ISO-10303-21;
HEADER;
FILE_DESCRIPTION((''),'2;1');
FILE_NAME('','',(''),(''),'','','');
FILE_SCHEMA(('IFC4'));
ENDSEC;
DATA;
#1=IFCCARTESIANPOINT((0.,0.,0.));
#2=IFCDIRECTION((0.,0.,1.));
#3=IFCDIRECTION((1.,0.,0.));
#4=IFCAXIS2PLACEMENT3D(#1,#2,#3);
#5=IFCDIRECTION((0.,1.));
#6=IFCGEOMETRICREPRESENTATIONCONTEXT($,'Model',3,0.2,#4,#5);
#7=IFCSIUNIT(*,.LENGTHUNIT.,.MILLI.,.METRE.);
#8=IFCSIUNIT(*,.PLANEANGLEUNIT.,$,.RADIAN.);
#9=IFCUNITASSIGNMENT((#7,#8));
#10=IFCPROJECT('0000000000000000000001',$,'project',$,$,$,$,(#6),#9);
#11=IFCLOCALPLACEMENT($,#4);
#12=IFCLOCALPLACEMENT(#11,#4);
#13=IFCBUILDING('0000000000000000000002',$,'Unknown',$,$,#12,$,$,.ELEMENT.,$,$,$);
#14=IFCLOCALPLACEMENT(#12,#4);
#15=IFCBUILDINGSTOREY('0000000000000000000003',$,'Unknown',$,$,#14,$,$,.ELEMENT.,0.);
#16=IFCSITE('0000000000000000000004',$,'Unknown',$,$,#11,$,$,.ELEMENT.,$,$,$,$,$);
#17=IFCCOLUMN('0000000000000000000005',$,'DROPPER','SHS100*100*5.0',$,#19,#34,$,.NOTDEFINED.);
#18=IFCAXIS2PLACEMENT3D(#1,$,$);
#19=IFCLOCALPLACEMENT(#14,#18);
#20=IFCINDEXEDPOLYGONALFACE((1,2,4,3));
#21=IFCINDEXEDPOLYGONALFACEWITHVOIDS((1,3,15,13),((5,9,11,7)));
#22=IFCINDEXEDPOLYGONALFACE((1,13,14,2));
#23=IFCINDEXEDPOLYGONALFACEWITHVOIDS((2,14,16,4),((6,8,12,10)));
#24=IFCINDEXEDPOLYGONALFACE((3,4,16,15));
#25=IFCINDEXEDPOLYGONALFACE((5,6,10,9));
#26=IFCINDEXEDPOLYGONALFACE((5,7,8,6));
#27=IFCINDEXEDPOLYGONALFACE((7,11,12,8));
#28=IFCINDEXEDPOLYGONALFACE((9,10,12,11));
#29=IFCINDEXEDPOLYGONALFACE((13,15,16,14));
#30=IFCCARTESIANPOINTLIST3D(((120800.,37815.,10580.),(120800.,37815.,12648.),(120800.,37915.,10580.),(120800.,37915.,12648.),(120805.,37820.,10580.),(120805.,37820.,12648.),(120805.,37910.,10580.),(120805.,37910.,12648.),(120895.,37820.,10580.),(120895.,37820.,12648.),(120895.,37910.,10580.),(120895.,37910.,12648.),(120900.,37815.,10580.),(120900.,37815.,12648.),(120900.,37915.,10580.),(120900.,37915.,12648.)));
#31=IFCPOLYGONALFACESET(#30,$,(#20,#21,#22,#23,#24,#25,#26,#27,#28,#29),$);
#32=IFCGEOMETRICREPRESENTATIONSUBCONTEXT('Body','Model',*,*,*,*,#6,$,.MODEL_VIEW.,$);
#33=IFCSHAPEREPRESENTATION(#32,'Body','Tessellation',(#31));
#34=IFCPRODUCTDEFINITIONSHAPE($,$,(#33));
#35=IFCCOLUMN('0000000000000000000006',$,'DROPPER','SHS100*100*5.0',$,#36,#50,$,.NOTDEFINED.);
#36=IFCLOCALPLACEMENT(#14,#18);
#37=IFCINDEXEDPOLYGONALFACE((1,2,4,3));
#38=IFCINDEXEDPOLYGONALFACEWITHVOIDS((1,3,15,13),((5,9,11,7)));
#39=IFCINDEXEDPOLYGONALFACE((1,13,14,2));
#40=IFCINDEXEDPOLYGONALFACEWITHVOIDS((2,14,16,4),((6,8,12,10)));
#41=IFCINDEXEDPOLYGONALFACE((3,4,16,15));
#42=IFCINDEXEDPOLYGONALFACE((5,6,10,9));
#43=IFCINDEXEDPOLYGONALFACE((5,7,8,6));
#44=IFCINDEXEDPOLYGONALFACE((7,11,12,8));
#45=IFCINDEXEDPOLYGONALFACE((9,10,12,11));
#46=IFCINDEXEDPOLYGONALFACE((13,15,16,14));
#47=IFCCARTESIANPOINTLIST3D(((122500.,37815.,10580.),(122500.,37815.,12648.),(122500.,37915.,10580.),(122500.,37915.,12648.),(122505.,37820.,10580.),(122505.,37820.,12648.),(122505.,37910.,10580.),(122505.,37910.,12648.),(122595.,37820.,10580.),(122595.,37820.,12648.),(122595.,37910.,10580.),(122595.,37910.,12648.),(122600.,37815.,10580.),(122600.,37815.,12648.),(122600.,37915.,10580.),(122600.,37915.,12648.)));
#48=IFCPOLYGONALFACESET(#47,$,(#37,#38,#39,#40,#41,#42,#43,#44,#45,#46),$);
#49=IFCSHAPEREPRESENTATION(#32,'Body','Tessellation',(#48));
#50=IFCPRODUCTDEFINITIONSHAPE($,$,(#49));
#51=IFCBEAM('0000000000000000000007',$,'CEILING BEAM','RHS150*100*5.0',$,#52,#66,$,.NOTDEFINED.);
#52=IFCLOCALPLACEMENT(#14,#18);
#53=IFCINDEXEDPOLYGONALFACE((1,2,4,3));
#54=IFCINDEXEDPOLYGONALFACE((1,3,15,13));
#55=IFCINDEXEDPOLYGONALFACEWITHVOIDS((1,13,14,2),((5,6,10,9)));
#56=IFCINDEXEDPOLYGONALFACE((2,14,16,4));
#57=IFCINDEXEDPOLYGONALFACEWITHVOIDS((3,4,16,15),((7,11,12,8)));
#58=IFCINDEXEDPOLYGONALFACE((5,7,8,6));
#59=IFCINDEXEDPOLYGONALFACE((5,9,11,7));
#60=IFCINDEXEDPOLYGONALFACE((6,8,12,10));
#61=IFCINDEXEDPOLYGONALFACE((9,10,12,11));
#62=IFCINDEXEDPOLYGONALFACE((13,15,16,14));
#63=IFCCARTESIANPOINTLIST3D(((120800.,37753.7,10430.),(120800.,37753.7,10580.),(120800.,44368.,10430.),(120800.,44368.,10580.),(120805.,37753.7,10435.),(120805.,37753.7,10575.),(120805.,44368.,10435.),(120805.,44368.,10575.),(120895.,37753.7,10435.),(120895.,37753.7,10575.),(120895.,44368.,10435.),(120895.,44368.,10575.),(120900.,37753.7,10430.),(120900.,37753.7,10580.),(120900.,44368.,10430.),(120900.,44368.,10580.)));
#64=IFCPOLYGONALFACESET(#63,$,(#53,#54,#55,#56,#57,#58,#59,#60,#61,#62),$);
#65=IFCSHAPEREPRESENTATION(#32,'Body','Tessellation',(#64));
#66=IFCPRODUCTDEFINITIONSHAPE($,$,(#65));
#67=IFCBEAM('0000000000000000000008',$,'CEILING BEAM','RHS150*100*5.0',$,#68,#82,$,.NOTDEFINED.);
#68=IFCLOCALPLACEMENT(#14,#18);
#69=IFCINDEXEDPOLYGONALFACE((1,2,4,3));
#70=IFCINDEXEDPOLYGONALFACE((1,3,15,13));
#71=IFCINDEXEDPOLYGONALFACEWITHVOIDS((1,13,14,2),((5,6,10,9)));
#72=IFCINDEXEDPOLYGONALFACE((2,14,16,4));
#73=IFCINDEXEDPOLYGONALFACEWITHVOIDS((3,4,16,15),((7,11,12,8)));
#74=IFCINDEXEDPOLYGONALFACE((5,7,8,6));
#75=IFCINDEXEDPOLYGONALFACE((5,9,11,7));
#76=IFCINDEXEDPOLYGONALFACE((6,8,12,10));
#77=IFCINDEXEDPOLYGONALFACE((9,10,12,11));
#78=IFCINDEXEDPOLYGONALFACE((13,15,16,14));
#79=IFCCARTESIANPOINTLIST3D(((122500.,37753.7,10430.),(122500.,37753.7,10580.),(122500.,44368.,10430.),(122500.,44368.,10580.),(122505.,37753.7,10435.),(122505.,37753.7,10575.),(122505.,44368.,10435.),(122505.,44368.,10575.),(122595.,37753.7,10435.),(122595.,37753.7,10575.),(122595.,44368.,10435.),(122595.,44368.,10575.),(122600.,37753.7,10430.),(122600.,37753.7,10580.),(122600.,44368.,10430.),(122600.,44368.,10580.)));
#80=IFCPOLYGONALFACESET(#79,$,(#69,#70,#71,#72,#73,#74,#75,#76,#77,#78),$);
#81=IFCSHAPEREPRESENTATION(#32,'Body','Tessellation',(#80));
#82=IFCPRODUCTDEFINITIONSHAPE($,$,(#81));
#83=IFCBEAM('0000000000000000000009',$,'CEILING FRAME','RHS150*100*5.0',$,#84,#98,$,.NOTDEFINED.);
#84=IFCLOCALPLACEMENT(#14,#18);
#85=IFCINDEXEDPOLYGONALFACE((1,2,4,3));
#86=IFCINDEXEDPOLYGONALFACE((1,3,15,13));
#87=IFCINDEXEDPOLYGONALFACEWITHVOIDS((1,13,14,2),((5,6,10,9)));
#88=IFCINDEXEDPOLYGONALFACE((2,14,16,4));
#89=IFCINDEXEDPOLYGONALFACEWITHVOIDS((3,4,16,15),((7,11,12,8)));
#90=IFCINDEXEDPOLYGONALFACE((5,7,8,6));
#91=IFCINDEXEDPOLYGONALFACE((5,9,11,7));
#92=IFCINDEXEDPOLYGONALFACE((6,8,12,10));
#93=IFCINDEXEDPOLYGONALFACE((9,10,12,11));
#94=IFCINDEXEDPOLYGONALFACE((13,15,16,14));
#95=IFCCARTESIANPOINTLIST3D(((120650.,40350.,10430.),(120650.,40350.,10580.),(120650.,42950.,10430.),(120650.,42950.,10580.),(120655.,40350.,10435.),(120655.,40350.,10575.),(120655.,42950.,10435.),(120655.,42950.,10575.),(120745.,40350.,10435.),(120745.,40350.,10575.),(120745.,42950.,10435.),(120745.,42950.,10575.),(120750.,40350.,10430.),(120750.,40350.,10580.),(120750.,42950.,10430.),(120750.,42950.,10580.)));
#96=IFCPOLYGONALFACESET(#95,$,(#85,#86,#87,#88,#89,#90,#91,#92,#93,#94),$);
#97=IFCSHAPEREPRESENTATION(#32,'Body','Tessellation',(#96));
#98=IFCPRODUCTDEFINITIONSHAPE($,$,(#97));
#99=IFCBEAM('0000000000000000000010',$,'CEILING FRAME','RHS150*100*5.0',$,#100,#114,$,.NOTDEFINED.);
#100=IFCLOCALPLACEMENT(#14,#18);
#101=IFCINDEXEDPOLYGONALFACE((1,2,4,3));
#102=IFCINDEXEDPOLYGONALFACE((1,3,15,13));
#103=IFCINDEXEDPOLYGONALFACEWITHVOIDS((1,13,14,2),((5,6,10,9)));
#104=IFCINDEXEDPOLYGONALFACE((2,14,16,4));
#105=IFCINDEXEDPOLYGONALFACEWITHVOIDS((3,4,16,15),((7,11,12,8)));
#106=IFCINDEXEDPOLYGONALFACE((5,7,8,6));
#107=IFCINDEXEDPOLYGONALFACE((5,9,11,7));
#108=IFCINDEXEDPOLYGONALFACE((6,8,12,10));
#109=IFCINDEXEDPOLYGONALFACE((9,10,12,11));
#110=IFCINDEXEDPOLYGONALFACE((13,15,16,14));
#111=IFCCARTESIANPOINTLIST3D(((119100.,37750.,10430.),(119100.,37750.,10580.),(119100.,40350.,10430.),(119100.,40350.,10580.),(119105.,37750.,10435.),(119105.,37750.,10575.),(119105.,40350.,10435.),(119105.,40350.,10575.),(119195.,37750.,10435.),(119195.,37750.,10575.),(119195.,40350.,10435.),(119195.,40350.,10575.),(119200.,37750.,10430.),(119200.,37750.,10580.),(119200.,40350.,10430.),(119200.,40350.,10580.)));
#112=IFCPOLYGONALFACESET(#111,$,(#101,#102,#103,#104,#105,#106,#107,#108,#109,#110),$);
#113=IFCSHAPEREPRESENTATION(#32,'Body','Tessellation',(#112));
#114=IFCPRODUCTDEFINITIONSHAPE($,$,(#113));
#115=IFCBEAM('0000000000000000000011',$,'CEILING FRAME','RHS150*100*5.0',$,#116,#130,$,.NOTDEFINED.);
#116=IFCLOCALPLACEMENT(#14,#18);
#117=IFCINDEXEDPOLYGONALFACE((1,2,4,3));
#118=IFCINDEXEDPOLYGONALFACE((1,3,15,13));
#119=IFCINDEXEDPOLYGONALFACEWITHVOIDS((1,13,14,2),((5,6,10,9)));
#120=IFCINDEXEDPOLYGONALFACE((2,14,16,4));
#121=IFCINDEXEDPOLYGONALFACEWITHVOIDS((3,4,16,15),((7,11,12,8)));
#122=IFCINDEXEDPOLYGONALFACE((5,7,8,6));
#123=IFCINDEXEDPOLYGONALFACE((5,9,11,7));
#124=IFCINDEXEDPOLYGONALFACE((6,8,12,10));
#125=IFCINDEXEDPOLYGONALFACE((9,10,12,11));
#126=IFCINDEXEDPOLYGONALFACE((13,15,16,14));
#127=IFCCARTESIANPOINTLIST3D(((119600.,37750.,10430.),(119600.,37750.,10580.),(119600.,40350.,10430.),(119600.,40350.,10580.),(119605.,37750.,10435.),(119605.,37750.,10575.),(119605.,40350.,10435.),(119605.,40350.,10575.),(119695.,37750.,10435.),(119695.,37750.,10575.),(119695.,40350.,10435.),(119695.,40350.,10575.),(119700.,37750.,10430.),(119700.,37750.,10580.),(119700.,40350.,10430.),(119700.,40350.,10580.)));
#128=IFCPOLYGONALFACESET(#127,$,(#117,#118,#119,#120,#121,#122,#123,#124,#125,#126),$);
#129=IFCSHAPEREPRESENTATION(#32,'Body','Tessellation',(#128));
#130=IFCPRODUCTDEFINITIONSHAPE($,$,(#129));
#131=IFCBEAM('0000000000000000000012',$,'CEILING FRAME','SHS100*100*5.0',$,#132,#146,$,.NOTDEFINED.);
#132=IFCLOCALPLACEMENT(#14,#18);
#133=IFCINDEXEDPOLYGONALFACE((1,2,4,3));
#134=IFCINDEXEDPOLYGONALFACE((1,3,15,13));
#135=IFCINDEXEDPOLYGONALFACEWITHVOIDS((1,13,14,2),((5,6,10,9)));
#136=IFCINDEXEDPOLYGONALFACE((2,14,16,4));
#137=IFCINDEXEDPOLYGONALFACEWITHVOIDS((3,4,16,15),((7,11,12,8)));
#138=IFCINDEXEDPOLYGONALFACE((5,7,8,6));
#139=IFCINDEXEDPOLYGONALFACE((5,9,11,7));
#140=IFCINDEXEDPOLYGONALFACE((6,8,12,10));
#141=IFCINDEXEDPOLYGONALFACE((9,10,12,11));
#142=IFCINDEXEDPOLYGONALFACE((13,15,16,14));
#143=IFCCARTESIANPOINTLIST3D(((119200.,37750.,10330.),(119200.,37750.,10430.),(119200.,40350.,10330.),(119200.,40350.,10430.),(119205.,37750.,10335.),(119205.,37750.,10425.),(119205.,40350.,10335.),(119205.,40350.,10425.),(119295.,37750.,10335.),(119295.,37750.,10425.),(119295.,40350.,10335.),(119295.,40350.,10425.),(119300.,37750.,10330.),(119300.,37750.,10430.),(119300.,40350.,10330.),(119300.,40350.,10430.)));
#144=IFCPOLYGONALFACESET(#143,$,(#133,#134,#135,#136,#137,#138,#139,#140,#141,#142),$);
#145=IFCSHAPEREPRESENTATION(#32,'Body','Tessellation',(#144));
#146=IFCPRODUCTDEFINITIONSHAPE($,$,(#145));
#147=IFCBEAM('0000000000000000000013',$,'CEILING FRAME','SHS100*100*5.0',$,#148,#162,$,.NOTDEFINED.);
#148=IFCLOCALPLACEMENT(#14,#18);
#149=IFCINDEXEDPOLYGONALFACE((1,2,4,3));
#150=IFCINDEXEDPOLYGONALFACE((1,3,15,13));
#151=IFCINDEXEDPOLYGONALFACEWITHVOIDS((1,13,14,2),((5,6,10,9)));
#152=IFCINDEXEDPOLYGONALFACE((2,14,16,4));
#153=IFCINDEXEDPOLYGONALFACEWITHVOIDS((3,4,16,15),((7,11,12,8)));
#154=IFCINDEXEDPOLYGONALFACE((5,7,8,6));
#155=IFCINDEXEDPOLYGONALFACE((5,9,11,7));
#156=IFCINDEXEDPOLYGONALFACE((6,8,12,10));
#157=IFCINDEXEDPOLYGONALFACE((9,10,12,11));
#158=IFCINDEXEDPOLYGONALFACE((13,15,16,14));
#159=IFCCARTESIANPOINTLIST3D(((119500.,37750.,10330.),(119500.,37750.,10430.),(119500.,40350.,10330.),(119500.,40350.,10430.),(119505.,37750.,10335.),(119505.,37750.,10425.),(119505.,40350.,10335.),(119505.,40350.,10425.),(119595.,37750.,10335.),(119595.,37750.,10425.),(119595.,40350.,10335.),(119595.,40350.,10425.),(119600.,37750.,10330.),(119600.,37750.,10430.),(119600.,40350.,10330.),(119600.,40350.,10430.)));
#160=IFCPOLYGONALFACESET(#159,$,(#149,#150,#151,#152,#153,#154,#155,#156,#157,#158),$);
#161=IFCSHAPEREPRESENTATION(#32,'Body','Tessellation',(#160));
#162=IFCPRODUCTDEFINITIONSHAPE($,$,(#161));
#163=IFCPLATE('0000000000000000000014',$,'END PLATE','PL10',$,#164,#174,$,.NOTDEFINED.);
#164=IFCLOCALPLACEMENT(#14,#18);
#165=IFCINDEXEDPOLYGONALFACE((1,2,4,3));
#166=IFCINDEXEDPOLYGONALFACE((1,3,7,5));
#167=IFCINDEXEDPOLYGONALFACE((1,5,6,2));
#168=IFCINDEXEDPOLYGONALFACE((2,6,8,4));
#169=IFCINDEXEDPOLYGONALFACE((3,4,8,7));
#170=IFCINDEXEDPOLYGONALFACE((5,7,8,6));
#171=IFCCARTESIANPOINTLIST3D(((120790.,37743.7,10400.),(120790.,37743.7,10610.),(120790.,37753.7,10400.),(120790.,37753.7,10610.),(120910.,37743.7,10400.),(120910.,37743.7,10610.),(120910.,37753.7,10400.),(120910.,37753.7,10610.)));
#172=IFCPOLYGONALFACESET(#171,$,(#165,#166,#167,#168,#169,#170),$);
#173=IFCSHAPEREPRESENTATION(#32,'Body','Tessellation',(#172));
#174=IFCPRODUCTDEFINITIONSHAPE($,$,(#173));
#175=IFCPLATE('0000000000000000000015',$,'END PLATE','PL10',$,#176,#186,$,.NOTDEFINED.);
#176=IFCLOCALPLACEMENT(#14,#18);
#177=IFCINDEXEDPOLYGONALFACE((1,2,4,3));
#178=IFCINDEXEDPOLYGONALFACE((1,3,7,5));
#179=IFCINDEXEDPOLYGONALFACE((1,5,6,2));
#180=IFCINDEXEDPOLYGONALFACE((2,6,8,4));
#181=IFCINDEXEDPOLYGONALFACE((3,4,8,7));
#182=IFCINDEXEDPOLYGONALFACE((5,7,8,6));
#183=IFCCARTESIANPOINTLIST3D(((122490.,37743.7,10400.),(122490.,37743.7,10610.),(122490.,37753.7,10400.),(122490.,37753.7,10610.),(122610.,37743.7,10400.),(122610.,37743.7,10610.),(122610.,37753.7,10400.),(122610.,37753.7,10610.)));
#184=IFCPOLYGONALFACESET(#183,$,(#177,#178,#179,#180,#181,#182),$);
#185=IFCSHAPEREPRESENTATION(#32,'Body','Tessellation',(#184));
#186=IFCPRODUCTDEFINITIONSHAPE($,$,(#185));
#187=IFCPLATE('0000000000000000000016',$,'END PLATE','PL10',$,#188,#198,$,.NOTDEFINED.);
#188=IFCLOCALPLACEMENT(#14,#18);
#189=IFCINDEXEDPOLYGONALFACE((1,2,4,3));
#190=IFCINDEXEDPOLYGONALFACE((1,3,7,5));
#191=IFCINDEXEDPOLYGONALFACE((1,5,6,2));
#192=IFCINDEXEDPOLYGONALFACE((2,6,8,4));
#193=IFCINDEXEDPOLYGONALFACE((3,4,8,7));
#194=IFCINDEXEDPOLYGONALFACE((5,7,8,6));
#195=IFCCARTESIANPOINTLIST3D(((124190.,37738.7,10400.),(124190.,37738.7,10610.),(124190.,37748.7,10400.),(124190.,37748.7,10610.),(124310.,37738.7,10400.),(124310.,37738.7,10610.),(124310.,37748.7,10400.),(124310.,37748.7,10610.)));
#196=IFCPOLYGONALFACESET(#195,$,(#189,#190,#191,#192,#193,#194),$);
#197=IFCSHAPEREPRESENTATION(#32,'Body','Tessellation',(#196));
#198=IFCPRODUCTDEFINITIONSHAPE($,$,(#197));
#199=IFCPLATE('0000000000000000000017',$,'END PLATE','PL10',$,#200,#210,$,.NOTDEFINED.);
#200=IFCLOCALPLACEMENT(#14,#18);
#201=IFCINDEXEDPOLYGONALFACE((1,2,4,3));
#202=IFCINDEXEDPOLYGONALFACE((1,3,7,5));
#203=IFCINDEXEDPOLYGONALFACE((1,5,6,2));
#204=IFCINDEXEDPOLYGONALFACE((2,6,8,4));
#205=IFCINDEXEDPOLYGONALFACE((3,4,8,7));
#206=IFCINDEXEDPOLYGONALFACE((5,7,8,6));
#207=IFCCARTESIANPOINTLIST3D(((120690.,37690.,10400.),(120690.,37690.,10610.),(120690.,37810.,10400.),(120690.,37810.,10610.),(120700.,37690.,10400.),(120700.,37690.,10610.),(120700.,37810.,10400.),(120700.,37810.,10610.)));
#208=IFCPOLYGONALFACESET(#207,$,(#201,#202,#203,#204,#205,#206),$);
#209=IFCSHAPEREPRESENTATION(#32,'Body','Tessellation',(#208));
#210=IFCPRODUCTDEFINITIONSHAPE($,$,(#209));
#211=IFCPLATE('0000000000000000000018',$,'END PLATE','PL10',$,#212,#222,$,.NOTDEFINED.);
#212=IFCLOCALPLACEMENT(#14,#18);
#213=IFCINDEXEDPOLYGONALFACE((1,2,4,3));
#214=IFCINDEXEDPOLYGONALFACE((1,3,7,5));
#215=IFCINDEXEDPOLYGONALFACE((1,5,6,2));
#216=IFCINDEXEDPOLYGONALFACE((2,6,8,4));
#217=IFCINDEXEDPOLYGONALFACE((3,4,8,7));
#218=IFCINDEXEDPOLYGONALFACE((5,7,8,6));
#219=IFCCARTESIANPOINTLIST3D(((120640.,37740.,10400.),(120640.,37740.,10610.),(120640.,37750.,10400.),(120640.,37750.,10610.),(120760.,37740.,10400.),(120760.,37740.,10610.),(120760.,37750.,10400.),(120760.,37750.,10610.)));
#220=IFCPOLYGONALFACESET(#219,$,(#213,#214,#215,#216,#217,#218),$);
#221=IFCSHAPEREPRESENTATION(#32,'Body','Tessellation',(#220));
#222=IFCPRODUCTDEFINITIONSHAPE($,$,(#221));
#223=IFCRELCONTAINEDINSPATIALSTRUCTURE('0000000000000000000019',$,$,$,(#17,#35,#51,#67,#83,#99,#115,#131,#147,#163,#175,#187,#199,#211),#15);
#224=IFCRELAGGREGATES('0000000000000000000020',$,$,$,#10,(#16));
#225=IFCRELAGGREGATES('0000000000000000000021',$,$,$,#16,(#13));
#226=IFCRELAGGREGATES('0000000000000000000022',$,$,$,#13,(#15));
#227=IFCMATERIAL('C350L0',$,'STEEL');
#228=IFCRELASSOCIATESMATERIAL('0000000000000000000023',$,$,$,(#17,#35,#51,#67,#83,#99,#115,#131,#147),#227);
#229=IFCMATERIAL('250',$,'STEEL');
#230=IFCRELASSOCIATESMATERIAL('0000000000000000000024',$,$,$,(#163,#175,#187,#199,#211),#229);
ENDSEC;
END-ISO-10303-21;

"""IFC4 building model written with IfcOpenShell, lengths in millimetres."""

from ifc_helpers import new_model, si_unit, direction, frame, origin_with_axes, place, context, subcontext, project, spatial, line, indexed_curve, outline, extrude, material, element, save


model = new_model("IFC4")

# Units and contexts
model_context = context("Model", 3, precision=0.2, world=origin_with_axes(), true_north=direction((0.0, 1.0)))
body_context = subcontext(model_context, "Body", "Model", "MODEL_VIEW")
ifc_project = project(units=[si_unit("LENGTHUNIT", "METRE", prefix="MILLI"), si_unit("PLANEANGLEUNIT", "RADIAN")], contexts=[model_context])

# Site, building, storey
site_placement = place(None, origin_with_axes())
site = spatial("IfcSite", under=ifc_project, at=site_placement, Name="Unknown", CompositionType="ELEMENT")
building_placement = place(site_placement, origin_with_axes())
building = spatial("IfcBuilding", under=site, at=building_placement, Name="Unknown", CompositionType="ELEMENT")
storey_placement = place(building_placement, origin_with_axes())
storey = spatial("IfcBuildingStorey", under=building, at=storey_placement, Name="Unknown", CompositionType="ELEMENT", Elevation=0.0)

# Columns
ifc_material_1 = material(Name="C350L0", Category="STEEL")
for number, where, z_axis, x_axis, name in (
    (1, (120850.0, 37865.0, 10580.0), (-1.0, 0.0, 0.0), (0.0, 0.0, 1.0), "DROPPER"),
    (2, (122550.0, 37865.0, 10580.0), (-1.0, 0.0, 0.0), (0.0, 0.0, 1.0), "DROPPER"),
):
    element("IfcColumn", number, at=place(storey_placement, frame(where, z_axis=z_axis, x_axis=x_axis)), inside=storey, material=ifc_material_1, Name=name, Description="SHS100*100*5.0", PredefinedType="NOTDEFINED", context=body_context, shape_type="SolidModel", body=[
        extrude(outline(indexed_curve([(-50.0, -50.0), (50.0, -50.0), (50.0, 50.0), (-50.0, 50.0)], segments=[line(1, 2, 3, 4, 1)]), holes=[indexed_curve([(-45.0, -45.0), (-45.0, 45.0), (45.0, 45.0), (45.0, -45.0)], segments=[line(1, 2, 3, 4, 1)])]), frame((0.0, 0.0, 0.0), z_axis=(-1.0, 0.0, 0.0), x_axis=(0.0, 0.0, 1.0)), (0.0, 0.0, -1.0), 2068.0),
    ])

# Beams
for number, where, z_axis, x_axis, name in (
    (3, (120850.0, 37753.7, 10505.0), (1.0, 0.0, 0.0), (0.0, 1.0, 0.0), "CEILING BEAM"),
    (4, (122550.0, 37753.7, 10505.0), (1.0, 0.0, 0.0), (0.0, 1.0, 0.0), "CEILING BEAM"),
):
    element("IfcBeam", number, at=place(storey_placement, frame(where, z_axis=z_axis, x_axis=x_axis)), inside=storey, material=ifc_material_1, Name=name, Description="RHS150*100*5.0", PredefinedType="NOTDEFINED", context=body_context, shape_type="SolidModel", body=[
        extrude(outline(indexed_curve([(-50.0, -75.0), (50.0, -75.0), (50.0, 75.0), (-50.0, 75.0)], segments=[line(1, 2, 3, 4, 1)]), holes=[indexed_curve([(-45.0, -70.0), (-45.0, 70.0), (45.0, 70.0), (45.0, -70.0)], segments=[line(1, 2, 3, 4, 1)])]), frame((0.0, 0.0, 0.0), z_axis=(-1.0, 0.0, 0.0), x_axis=(0.0, 0.0, 1.0)), (0.0, 0.0, -1.0), 6614.3),
    ])
for number, where, z_axis, x_axis, name in (
    (5, (120700.0, 40350.0, 10505.0), (1.0, 0.0, 0.0), (0.0, 1.0, 0.0), "CEILING FRAME"),
    (6, (119150.0, 37750.0, 10505.0), (1.0, 0.0, 0.0), (0.0, 1.0, 0.0), "CEILING FRAME"),
    (7, (119650.0, 37750.0, 10505.0), (1.0, 0.0, 0.0), (0.0, 1.0, 0.0), "CEILING FRAME"),
):
    element("IfcBeam", number, at=place(storey_placement, frame(where, z_axis=z_axis, x_axis=x_axis)), inside=storey, material=ifc_material_1, Name=name, Description="RHS150*100*5.0", PredefinedType="NOTDEFINED", context=body_context, shape_type="SolidModel", body=[
        extrude(outline(indexed_curve([(-50.0, -75.0), (50.0, -75.0), (50.0, 75.0), (-50.0, 75.0)], segments=[line(1, 2, 3, 4, 1)]), holes=[indexed_curve([(-45.0, -70.0), (-45.0, 70.0), (45.0, 70.0), (45.0, -70.0)], segments=[line(1, 2, 3, 4, 1)])]), frame((0.0, 0.0, 0.0), z_axis=(-1.0, 0.0, 0.0), x_axis=(0.0, 0.0, 1.0)), (0.0, 0.0, -1.0), 2600.0),
    ])
for number, where, z_axis, x_axis, name in (
    (8, (119250.0, 37750.0, 10380.0), (0.0, 0.0, 1.0), (0.0, 1.0, 0.0), "CEILING FRAME"),
    (9, (119550.0, 37750.0, 10380.0), (0.0, 0.0, 1.0), (0.0, 1.0, 0.0), "CEILING FRAME"),
):
    element("IfcBeam", number, at=place(storey_placement, frame(where, z_axis=z_axis, x_axis=x_axis)), inside=storey, material=ifc_material_1, Name=name, Description="SHS100*100*5.0", PredefinedType="NOTDEFINED", context=body_context, shape_type="SolidModel", body=[
        extrude(outline(indexed_curve([(-50.0, -50.0), (50.0, -50.0), (50.0, 50.0), (-50.0, 50.0)], segments=[line(1, 2, 3, 4, 1)]), holes=[indexed_curve([(-45.0, -45.0), (-45.0, 45.0), (45.0, 45.0), (45.0, -45.0)], segments=[line(1, 2, 3, 4, 1)])]), frame((0.0, 0.0, 0.0), z_axis=(-1.0, 0.0, 0.0), x_axis=(0.0, 0.0, 1.0)), (0.0, 0.0, -1.0), 2600.0),
    ])

# Plates
ifc_material_2 = material(Name="250", Category="STEEL")
for number, where, z_axis, x_axis, name in (
    (10, (120790.0, 37748.7, 10400.0), (0.0, -1.0, 0.0), (1.0, 0.0, 0.0), "END PLATE"),
    (11, (122490.0, 37748.7, 10400.0), (0.0, -1.0, 0.0), (1.0, 0.0, 0.0), "END PLATE"),
    (12, (124190.0, 37743.7, 10400.0), (0.0, -1.0, 0.0), (1.0, 0.0, 0.0), "END PLATE"),
    (13, (120695.0, 37810.0, 10400.0), (-1.0, 0.0, 0.0), (0.0, -1.0, 0.0), "END PLATE"),
    (14, (120640.0, 37745.0, 10400.0), (0.0, -1.0, 0.0), (1.0, 0.0, 0.0), "END PLATE"),
):
    element("IfcPlate", number, at=place(storey_placement, frame(where, z_axis=z_axis, x_axis=x_axis)), inside=storey, material=ifc_material_2, Name=name, Description="PL10", PredefinedType="NOTDEFINED", context=body_context, shape_type="SolidModel", body=[
        extrude(outline(indexed_curve([(0.0, 0.0), (120.0, 0.0), (120.0, 210.0), (0.0, 210.0)], segments=[line(1, 2, 3, 4, 1)])), frame((0.0, 0.0, 5.0), z_axis=(0.0, 0.0, 1.0), x_axis=(1.0, 0.0, 0.0)), (0.0, 0.0, -1.0), 10.0),
    ])

save(model, "model.ifc")
